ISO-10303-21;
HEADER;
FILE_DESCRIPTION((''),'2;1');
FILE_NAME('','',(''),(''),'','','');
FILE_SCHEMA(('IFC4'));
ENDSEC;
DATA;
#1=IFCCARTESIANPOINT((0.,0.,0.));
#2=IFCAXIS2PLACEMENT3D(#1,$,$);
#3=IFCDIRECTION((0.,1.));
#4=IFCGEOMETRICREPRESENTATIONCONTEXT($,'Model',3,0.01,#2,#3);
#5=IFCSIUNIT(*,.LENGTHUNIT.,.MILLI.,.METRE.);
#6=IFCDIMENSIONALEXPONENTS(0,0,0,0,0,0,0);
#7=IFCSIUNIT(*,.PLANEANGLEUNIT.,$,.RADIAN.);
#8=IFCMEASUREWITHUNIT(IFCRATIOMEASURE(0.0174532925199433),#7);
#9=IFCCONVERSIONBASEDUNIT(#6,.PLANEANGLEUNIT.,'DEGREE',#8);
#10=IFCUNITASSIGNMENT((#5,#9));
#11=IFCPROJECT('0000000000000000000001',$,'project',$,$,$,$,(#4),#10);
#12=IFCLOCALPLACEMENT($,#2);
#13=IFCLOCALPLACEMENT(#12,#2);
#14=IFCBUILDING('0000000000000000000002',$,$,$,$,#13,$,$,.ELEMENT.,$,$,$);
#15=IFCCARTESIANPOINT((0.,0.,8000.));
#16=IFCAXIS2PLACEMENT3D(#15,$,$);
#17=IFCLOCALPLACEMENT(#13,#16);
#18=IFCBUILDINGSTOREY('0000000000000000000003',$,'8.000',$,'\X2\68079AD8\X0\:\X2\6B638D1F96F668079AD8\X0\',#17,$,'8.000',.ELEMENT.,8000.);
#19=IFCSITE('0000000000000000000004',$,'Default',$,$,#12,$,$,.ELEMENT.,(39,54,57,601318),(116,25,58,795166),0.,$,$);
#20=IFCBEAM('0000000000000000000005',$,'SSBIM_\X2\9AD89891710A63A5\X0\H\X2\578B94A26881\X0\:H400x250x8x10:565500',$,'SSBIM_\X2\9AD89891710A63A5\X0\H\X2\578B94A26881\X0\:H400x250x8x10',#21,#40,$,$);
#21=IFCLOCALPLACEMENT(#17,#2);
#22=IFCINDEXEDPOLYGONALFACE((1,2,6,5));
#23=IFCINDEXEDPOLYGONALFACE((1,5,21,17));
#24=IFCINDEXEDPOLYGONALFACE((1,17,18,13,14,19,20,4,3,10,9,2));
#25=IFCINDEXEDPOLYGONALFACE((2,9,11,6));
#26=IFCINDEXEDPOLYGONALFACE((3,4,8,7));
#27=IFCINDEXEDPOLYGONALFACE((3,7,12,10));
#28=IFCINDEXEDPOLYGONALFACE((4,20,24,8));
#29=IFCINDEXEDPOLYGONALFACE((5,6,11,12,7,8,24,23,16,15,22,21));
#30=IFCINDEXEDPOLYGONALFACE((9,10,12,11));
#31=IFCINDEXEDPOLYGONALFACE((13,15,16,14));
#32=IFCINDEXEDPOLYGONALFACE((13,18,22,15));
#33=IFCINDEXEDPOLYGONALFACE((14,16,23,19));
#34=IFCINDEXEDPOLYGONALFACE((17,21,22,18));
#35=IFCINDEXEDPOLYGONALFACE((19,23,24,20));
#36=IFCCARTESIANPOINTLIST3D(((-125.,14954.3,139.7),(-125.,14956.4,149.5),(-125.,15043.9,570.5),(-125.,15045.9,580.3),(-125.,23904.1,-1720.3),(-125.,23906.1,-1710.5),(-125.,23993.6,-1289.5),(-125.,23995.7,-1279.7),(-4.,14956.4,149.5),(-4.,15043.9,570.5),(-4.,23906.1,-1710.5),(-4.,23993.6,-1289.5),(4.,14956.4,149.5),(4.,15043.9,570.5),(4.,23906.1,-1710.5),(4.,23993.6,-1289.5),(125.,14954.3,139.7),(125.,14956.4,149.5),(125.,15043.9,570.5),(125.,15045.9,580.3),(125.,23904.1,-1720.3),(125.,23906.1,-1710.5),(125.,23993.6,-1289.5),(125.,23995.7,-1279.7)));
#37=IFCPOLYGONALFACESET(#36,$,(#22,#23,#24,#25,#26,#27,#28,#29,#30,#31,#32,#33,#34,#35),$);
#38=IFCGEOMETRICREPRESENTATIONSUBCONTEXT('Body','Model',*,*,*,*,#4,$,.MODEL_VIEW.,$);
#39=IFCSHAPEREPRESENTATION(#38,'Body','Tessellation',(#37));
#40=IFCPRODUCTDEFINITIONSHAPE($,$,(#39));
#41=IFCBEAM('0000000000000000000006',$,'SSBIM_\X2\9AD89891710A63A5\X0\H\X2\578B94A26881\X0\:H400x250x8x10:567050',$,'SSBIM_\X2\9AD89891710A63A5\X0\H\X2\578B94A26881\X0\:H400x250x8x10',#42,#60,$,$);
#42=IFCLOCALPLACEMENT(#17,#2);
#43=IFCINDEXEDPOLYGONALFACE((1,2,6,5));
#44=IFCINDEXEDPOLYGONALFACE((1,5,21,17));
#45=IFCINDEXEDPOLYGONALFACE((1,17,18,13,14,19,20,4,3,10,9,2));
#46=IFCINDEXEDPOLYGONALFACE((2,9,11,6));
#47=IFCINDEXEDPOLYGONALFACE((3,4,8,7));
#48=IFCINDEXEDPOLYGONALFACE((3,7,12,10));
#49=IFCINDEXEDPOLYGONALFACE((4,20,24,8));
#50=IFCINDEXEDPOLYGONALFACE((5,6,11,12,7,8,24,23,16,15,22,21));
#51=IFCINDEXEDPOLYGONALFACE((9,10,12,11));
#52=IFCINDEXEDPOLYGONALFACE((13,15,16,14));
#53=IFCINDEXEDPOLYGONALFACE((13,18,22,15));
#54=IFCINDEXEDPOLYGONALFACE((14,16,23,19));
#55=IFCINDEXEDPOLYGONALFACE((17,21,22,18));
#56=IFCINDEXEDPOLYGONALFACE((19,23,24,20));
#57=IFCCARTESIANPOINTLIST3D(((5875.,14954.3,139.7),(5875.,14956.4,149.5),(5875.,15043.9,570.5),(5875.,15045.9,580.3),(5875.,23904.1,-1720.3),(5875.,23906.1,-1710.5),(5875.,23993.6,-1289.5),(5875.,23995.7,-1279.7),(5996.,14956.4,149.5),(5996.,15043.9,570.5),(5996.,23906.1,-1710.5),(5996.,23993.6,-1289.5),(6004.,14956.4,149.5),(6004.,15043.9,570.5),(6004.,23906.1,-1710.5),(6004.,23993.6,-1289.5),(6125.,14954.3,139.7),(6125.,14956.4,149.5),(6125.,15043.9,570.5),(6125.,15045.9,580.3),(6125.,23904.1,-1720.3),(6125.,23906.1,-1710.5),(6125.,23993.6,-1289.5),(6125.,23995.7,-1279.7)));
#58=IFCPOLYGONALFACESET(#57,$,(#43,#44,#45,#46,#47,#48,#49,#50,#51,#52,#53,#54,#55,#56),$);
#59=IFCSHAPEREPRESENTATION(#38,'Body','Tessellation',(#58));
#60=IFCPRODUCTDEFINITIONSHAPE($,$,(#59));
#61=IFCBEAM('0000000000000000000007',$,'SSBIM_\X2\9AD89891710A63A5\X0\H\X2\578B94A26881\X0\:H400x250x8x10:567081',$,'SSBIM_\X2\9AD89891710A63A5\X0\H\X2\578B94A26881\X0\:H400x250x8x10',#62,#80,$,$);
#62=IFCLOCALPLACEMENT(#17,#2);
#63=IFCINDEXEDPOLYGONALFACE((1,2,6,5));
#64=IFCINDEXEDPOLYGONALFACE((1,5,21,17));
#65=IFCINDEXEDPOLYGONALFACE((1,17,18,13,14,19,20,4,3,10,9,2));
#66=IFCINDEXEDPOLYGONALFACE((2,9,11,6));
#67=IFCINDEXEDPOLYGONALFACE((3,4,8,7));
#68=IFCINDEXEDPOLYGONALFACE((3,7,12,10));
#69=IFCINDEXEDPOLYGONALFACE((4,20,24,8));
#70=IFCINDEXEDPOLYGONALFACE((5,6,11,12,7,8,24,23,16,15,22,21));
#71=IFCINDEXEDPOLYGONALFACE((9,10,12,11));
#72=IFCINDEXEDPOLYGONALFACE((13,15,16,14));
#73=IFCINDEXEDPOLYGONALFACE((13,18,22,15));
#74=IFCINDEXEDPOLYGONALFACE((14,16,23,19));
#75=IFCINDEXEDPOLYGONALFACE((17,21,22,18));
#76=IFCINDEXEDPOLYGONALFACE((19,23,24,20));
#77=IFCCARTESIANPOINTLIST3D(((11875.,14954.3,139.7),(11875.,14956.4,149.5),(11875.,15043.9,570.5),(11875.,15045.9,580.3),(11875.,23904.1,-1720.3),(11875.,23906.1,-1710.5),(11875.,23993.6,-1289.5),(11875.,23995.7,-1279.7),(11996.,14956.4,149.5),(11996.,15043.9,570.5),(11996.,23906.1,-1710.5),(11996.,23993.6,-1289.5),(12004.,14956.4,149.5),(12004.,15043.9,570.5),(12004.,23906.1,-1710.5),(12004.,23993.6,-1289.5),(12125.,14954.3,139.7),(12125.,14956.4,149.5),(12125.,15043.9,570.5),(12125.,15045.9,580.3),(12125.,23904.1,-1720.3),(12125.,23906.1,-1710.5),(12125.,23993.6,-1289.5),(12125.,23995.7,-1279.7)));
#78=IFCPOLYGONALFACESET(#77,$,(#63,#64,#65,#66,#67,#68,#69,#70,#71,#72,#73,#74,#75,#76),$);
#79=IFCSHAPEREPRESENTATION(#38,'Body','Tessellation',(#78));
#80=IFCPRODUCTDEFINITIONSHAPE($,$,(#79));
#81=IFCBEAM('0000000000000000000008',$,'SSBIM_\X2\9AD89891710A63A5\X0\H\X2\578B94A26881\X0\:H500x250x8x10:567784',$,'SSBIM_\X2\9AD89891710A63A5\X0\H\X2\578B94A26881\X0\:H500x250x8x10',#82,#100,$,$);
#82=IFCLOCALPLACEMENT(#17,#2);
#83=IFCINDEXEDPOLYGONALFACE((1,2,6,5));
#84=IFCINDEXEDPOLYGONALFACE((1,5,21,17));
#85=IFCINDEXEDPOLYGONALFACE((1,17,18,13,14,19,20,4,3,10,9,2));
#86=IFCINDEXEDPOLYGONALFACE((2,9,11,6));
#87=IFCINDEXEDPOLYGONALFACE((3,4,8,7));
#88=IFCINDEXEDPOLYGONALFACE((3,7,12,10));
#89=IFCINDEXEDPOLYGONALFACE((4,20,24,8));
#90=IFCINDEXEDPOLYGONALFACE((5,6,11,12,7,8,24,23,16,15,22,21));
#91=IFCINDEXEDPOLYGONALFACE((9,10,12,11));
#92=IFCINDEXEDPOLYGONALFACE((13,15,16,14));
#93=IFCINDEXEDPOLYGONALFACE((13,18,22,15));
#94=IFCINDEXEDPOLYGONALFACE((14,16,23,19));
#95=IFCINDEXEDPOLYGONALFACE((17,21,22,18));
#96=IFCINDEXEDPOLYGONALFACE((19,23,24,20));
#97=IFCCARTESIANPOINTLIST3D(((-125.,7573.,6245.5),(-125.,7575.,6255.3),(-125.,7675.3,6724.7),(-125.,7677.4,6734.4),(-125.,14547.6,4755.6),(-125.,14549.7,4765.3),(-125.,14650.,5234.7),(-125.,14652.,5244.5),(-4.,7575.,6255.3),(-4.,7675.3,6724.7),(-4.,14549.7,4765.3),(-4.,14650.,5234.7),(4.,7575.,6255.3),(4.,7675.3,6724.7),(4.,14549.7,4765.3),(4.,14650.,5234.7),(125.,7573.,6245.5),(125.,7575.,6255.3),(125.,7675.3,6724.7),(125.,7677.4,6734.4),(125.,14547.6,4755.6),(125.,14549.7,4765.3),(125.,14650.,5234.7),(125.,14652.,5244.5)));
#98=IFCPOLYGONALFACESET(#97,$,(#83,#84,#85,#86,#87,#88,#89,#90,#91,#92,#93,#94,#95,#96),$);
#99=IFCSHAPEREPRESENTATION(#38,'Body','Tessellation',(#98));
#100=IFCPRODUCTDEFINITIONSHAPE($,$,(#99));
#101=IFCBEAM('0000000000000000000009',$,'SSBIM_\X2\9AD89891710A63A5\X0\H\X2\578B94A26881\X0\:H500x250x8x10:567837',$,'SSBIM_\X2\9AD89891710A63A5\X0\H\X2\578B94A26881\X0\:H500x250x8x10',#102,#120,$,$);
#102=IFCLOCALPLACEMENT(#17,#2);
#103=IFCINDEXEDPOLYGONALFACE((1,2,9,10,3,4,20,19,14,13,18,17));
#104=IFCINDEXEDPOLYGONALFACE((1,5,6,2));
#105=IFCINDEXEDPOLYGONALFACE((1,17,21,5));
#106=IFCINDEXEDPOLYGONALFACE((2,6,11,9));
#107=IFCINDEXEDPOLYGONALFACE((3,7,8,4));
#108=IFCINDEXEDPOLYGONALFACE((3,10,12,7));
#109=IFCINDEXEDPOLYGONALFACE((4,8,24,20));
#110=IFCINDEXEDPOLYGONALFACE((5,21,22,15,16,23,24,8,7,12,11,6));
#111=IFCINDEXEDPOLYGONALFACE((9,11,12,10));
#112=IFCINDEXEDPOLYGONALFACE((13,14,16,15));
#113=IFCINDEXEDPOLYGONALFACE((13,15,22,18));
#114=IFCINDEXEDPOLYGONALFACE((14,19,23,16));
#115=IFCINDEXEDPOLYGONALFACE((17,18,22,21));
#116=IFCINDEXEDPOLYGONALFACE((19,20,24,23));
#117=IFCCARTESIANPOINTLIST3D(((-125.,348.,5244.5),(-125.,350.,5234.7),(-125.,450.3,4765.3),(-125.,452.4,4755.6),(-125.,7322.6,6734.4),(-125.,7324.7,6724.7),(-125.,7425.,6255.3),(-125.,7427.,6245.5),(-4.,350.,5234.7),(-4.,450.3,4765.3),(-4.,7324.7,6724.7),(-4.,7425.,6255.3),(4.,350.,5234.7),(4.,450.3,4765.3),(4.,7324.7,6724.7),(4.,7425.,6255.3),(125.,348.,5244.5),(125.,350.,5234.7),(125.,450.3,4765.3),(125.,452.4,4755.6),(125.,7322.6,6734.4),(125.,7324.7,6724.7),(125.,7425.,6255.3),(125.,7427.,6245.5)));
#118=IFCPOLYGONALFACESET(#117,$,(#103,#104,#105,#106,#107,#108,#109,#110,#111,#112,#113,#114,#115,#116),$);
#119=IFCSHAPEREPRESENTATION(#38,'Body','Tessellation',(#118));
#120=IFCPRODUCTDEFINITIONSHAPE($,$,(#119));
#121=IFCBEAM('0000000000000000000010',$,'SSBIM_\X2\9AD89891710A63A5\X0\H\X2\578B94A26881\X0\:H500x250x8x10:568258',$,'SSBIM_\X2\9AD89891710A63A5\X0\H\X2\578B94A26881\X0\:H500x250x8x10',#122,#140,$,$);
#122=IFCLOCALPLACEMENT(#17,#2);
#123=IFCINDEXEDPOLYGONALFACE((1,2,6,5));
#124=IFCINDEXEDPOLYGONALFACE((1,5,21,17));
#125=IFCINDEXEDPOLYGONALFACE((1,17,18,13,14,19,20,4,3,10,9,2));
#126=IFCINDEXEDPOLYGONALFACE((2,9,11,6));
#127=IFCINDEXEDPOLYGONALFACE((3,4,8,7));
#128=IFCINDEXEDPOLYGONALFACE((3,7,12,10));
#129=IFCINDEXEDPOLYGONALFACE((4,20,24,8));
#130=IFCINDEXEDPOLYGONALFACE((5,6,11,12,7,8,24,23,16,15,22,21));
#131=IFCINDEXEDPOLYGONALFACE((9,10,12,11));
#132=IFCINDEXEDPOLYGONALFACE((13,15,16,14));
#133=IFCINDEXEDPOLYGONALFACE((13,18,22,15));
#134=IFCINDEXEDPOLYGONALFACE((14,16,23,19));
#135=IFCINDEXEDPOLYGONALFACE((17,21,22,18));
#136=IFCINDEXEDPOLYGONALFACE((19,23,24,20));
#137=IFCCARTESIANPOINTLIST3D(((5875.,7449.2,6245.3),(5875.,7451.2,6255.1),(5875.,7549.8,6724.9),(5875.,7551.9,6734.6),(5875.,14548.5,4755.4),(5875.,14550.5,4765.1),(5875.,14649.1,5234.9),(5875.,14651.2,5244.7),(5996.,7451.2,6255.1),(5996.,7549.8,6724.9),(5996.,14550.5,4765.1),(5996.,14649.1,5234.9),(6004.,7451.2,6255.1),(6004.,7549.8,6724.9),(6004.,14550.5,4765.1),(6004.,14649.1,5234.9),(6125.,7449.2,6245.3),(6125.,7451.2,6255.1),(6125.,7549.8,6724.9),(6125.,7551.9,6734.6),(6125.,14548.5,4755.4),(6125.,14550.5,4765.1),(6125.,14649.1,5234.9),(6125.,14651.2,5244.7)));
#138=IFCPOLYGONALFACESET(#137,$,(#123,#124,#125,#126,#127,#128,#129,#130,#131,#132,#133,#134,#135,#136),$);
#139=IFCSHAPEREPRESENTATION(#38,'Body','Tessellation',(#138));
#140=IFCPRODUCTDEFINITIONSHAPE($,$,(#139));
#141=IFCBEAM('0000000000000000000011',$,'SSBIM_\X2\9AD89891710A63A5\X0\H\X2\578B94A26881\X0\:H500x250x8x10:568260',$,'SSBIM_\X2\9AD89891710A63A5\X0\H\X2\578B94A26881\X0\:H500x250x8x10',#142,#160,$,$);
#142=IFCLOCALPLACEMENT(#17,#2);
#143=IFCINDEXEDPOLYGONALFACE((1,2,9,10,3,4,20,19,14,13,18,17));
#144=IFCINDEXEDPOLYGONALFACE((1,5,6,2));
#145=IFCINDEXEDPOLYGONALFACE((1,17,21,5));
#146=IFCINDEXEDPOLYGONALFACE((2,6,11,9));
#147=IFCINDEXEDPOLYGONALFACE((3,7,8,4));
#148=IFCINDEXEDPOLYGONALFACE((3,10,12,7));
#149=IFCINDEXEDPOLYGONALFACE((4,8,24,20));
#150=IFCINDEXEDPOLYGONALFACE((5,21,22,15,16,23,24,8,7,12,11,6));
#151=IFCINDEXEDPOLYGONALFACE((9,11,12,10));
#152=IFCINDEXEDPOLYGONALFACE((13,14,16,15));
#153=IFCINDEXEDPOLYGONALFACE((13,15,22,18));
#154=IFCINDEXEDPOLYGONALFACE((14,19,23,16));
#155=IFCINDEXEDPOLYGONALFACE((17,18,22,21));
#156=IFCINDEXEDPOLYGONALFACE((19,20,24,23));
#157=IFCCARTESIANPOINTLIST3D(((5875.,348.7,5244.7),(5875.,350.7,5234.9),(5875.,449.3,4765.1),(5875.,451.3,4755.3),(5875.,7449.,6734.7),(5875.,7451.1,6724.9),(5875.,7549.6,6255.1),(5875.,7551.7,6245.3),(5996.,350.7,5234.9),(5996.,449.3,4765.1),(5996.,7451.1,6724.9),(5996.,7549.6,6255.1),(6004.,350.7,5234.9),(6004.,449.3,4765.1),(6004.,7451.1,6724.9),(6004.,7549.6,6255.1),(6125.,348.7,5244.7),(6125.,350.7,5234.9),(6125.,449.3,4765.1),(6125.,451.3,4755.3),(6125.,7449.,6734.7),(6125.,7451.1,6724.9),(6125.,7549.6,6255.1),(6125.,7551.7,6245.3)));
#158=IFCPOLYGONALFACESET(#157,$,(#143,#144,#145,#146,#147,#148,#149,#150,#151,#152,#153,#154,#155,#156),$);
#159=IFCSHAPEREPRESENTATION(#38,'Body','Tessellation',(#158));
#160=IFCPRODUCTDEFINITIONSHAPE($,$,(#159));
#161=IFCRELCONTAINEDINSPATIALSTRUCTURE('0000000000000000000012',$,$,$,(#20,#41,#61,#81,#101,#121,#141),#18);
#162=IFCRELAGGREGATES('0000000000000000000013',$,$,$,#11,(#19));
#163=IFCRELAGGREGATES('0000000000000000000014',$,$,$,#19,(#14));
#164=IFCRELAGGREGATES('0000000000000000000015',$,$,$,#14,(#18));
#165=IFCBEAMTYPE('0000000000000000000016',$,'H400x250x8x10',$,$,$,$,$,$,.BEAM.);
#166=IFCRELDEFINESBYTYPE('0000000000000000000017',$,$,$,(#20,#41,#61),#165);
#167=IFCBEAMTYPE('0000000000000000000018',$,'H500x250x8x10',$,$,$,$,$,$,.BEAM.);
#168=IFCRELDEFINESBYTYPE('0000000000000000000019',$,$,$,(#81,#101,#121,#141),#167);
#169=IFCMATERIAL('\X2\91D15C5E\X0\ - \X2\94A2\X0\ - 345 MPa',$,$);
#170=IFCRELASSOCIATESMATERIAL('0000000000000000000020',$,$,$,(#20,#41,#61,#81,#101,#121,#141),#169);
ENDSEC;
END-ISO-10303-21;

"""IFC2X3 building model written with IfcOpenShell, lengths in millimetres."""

from ifc_helpers import new_model, entity, si_unit, converted_unit, direction, frame, frame_2d, origin, place, context, subcontext, project, spatial, i_section, extrude, material, type_object, element, save


model = new_model("IFC2X3")

# Units and contexts
model_context = context("Model", 3, precision=0.01, world=origin(), true_north=direction((0.0, 1.0)))
body_context = subcontext(model_context, "Body", "Model", "MODEL_VIEW")
ifc_project = project(units=[si_unit("LENGTHUNIT", "METRE", prefix="MILLI"), converted_unit("PLANEANGLEUNIT", "DEGREE", entity("IfcRatioMeasure", 0.0174532925199433), si_unit("PLANEANGLEUNIT", "RADIAN"), dimensions=[0, 0, 0, 0, 0, 0, 0])], contexts=[model_context])

# Site, building, storey
site_placement = place(None, origin())
site = spatial("IfcSite", under=ifc_project, at=site_placement, Name="Default", CompositionType="ELEMENT", RefLatitude=(39, 54, 57, 601318), RefLongitude=(116, 25, 58, 795166), RefElevation=0.0)
building_placement = place(site_placement, origin())
building = spatial("IfcBuilding", under=site, at=building_placement, CompositionType="ELEMENT")
storey_placement = place(building_placement, frame((0.0, 0.0, 8000.0)))
storey = spatial("IfcBuildingStorey", under=building, at=storey_placement, Name="8.000", ObjectType="标高:正负零标高", LongName="8.000", CompositionType="ELEMENT", Elevation=8000.0)

# Beams
ifc_material_1 = material(Name="金属 - 钢 - 345 MPa")
beam_type_1 = type_object("IfcBeamType", Name="H400x250x8x10", PredefinedType="BEAM")
beam_1_placement = place(storey_placement, frame((0.0, 23950.0, -1500.0), z_axis=(0.0, 0.203474, 0.97908), x_axis=(0.0, -0.97908, 0.203474)))
element("IfcBeam", 1, at=beam_1_placement, inside=storey, type_object=beam_type_1, material=ifc_material_1, Name="SSBIM_高频焊接H型钢梁:H400x250x8x10:565500", ObjectType="SSBIM_高频焊接H型钢梁:H400x250x8x10", context=body_context, shape_type="SweptSolid", body=[
    extrude(i_section(OverallWidth=250.0, OverallDepth=450.0, WebThickness=8.0, FlangeThickness=10.0, at=frame_2d((0.0, 0.0), x_axis=(0.0, 1.0))), frame((0.1, 0.0, 0.0), z_axis=(1.0, 0.0, 0.0), x_axis=(0.0, 0.0, -1.0)), (0.0, 0.0, 1.0), 9141.0),
])
beam_2_placement = place(storey_placement, frame((6000.0, 23950.0, -1500.0), z_axis=(0.0, 0.203474, 0.97908), x_axis=(0.0, -0.97908, 0.203474)))
element("IfcBeam", 2, at=beam_2_placement, inside=storey, type_object=beam_type_1, material=ifc_material_1, Name="SSBIM_高频焊接H型钢梁:H400x250x8x10:567050", ObjectType="SSBIM_高频焊接H型钢梁:H400x250x8x10", context=body_context, shape_type="SweptSolid", body=[
    extrude(i_section(OverallWidth=250.0, OverallDepth=450.0, WebThickness=8.0, FlangeThickness=10.0, at=frame_2d((0.0, 0.0), x_axis=(0.0, 1.0))), frame((0.1, 0.0, 0.0), z_axis=(1.0, 0.0, 0.0), x_axis=(0.0, 0.0, -1.0)), (0.0, 0.0, 1.0), 9141.0),
])
beam_3_placement = place(storey_placement, frame((12000.0, 23950.0, -1500.0), z_axis=(0.0, 0.203474, 0.97908), x_axis=(0.0, -0.97908, 0.203474)))
element("IfcBeam", 3, at=beam_3_placement, inside=storey, type_object=beam_type_1, material=ifc_material_1, Name="SSBIM_高频焊接H型钢梁:H400x250x8x10:567081", ObjectType="SSBIM_高频焊接H型钢梁:H400x250x8x10", context=body_context, shape_type="SweptSolid", body=[
    extrude(i_section(OverallWidth=250.0, OverallDepth=450.0, WebThickness=8.0, FlangeThickness=10.0, at=frame_2d((0.0, 0.0), x_axis=(0.0, 1.0))), frame((0.1, 0.0, 0.0), z_axis=(1.0, 0.0, 0.0), x_axis=(0.0, 0.0, -1.0)), (0.0, 0.0, 1.0), 9141.0),
])
beam_type_2 = type_object("IfcBeamType", Name="H500x250x8x10", PredefinedType="BEAM")
beam_4_placement = place(storey_placement, frame((0.0, 14600.0, 5000.0), z_axis=(0.0, 0.208907, 0.977936), x_axis=(0.0, -0.977936, 0.208907)))
element("IfcBeam", 4, at=beam_4_placement, inside=storey, type_object=beam_type_2, material=ifc_material_1, Name="SSBIM_高频焊接H型钢梁:H500x250x8x10:567784", ObjectType="SSBIM_高频焊接H型钢梁:H500x250x8x10", context=body_context, shape_type="SweptSolid", body=[
    extrude(i_section(OverallWidth=250.0, OverallDepth=500.0, WebThickness=8.0, FlangeThickness=10.0, at=frame_2d((0.0, 0.0), x_axis=(0.0, 1.0))), frame((0.2, 0.0, 0.0), z_axis=(1.0, 0.0, 0.0), x_axis=(0.0, 0.0, -1.0)), (0.0, 0.0, 1.0), 7132.0),
])
beam_5_placement = place(storey_placement, frame((0.0, 7375.0, 6490.0), z_axis=(0.0, -0.208907, 0.977936), x_axis=(0.0, -0.977936, -0.208907)))
element("IfcBeam", 5, at=beam_5_placement, inside=storey, type_object=beam_type_2, material=ifc_material_1, Name="SSBIM_高频焊接H型钢梁:H500x250x8x10:567837", ObjectType="SSBIM_高频焊接H型钢梁:H500x250x8x10", context=body_context, shape_type="SweptSolid", body=[
    extrude(i_section(OverallWidth=250.0, OverallDepth=500.0, WebThickness=8.0, FlangeThickness=10.0, at=frame_2d((0.0, 0.0), x_axis=(0.0, 1.0))), frame((0.2, 0.0, 0.0), z_axis=(1.0, 0.0, 0.0), x_axis=(0.0, 0.0, -1.0)), (0.0, 0.0, 1.0), 7132.0),
])
beam_6_placement = place(storey_placement, frame((6000.0, 14600.0, 5000.0), z_axis=(0.0, 0.205395, 0.978679), x_axis=(0.0, -0.978679, 0.205395)))
element("IfcBeam", 6, at=beam_6_placement, inside=storey, type_object=beam_type_2, material=ifc_material_1, Name="SSBIM_高频焊接H型钢梁:H500x250x8x10:568258", ObjectType="SSBIM_高频焊接H型钢梁:H500x250x8x10", context=body_context, shape_type="SweptSolid", body=[
    extrude(i_section(OverallWidth=250.0, OverallDepth=500.0, WebThickness=8.0, FlangeThickness=10.0, at=frame_2d((0.0, 0.0), x_axis=(0.0, 1.0))), frame((0.2, 0.0, 0.0), z_axis=(1.0, 0.0, 0.0), x_axis=(0.0, 0.0, -1.0)), (0.0, 0.0, 1.0), 7254.0),
])
beam_7_placement = place(storey_placement, frame((6000.0, 7500.3, 6490.0), z_axis=(0.0, -0.205376, 0.978683), x_axis=(0.0, -0.978683, -0.205376)))
element("IfcBeam", 7, at=beam_7_placement, inside=storey, type_object=beam_type_2, material=ifc_material_1, Name="SSBIM_高频焊接H型钢梁:H500x250x8x10:568260", ObjectType="SSBIM_高频焊接H型钢梁:H500x250x8x10", context=body_context, shape_type="SweptSolid", body=[
    extrude(i_section(OverallWidth=250.0, OverallDepth=500.0, WebThickness=8.0, FlangeThickness=10.0, at=frame_2d((0.0, 0.0), x_axis=(0.0, 1.0))), frame((0.0, 0.0, 0.0), z_axis=(1.0, 0.0, 0.0), x_axis=(0.0, 0.0, -1.0)), (0.0, 0.0, 1.0), 7255.0),
])

save(model, "model.ifc")
